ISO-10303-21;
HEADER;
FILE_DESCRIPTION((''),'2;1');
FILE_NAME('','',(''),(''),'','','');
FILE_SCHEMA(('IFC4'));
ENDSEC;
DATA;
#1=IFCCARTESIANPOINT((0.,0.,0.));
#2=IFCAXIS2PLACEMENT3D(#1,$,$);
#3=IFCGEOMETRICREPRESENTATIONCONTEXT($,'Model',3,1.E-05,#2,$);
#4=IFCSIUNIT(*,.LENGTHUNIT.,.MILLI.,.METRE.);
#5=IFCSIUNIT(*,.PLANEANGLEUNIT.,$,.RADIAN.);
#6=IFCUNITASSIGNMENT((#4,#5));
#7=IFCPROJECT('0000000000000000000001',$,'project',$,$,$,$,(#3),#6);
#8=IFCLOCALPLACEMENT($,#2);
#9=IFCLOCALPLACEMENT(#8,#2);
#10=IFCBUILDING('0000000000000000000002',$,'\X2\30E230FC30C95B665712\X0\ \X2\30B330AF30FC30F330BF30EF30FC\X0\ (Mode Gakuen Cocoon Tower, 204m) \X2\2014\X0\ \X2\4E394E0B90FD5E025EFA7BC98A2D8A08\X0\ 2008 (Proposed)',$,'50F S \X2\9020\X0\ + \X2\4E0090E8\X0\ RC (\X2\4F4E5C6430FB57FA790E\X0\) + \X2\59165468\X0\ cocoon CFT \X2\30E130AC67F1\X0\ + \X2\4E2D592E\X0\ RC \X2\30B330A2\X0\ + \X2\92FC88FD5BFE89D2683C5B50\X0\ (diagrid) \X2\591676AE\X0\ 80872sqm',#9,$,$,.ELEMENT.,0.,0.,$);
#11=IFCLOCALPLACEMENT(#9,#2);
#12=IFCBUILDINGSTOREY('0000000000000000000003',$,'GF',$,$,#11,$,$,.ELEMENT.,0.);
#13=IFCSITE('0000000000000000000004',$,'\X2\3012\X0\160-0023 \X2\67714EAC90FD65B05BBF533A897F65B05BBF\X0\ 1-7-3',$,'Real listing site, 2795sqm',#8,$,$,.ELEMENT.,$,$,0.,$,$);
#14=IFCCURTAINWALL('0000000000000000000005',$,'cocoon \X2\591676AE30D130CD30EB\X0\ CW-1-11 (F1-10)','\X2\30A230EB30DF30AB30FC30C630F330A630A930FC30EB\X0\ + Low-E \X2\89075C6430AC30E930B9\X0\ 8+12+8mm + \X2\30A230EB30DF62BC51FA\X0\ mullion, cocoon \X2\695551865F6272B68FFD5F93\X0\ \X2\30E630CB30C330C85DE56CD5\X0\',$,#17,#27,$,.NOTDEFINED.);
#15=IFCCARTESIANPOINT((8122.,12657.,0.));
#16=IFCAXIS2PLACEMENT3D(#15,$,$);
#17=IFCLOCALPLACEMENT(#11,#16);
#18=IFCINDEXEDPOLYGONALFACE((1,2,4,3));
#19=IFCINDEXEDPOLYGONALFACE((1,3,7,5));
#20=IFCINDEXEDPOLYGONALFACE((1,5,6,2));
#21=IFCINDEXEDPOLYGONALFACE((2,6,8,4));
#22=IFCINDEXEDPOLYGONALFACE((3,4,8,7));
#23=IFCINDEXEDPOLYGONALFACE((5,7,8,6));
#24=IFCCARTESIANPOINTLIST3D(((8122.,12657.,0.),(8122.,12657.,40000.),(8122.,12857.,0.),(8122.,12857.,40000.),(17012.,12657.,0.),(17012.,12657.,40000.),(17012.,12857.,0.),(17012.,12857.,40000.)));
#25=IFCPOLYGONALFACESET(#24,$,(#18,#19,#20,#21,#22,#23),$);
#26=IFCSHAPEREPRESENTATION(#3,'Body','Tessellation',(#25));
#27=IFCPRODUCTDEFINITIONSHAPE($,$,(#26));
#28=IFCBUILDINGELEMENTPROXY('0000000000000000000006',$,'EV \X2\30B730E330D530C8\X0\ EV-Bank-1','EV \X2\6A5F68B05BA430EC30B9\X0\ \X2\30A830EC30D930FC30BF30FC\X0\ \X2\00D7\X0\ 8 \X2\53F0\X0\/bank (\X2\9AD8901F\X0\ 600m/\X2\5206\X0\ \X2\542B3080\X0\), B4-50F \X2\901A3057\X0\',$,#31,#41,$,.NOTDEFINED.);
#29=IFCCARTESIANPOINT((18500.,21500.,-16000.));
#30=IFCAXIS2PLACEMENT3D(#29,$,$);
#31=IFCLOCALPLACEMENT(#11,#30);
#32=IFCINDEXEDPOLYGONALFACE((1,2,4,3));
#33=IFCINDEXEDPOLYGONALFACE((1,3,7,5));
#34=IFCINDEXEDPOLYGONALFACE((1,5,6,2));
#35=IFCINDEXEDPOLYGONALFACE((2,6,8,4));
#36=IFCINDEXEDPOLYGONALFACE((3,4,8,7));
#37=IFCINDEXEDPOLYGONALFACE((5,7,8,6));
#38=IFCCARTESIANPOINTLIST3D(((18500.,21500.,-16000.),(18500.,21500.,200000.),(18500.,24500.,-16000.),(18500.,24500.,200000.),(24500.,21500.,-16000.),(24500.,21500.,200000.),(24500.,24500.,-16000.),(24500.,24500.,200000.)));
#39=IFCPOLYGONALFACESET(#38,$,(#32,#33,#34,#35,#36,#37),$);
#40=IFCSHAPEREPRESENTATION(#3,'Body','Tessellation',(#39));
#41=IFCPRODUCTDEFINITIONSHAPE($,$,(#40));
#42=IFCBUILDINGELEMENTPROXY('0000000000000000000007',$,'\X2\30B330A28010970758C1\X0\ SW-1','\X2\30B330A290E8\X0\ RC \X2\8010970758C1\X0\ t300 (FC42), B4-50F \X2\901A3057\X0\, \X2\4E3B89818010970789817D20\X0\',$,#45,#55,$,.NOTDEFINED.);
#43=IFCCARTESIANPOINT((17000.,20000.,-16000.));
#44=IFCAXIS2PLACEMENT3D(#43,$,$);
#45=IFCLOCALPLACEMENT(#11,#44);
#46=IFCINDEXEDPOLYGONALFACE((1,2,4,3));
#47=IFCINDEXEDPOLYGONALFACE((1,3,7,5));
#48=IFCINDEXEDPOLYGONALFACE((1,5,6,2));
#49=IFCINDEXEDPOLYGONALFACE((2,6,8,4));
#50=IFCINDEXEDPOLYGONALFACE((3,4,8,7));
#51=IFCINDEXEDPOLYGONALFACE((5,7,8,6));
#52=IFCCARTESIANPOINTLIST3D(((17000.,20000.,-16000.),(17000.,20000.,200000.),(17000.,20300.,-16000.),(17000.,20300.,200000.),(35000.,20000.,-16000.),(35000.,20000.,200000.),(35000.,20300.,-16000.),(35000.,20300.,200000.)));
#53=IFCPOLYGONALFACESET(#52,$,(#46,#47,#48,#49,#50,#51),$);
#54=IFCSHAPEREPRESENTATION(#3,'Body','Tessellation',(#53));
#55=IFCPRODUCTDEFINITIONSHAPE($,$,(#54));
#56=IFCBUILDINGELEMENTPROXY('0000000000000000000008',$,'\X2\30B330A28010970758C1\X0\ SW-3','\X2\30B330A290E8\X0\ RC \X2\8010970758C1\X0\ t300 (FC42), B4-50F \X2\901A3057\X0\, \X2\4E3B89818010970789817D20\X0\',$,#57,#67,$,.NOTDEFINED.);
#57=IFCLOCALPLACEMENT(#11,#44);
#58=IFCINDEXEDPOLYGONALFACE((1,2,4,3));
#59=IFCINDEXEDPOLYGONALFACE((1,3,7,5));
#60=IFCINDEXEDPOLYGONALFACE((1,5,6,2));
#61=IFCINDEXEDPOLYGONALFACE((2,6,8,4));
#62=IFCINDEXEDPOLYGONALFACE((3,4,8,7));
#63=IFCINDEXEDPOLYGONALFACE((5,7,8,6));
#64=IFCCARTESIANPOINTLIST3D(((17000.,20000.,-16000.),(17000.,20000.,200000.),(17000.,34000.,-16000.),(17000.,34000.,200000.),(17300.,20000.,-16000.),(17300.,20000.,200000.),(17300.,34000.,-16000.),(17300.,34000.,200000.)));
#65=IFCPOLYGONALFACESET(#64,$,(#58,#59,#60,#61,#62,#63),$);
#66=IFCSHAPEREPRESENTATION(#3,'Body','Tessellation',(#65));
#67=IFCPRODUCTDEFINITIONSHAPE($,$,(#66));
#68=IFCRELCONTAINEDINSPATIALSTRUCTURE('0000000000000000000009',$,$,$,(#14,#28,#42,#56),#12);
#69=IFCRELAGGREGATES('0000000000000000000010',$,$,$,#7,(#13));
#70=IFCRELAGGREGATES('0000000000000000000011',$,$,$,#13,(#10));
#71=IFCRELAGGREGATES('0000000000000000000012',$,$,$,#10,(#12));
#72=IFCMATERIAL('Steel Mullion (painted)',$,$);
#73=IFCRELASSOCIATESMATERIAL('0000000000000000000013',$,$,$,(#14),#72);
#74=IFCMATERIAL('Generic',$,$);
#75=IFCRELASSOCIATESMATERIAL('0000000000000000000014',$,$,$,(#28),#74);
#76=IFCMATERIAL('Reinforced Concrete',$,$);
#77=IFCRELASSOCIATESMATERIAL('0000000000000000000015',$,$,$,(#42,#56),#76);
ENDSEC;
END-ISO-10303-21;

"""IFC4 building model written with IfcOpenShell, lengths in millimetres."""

from ifc_helpers import new_model, si_unit, frame, frame_2d, origin, place, context, project, spatial, rectangle, extrude, material, element, save


model = new_model("IFC4")

# Units and contexts
model_context = context("Model", 3, precision=1e-05, world=origin())
ifc_project = project(units=[si_unit("LENGTHUNIT", "METRE", prefix="MILLI"), si_unit("PLANEANGLEUNIT", "RADIAN")], contexts=[model_context])

# Site, building, storey
site_placement = place(None, origin())
site = spatial("IfcSite", under=ifc_project, at=site_placement, Name="〒160-0023 東京都新宿区西新宿 1-7-3", ObjectType="Real listing site, 2795sqm", CompositionType="ELEMENT", RefElevation=0.0)
building_placement = place(site_placement, origin())
building = spatial("IfcBuilding", under=site, at=building_placement, Name="モード学園 コクーンタワー (Mode Gakuen Cocoon Tower, 204m) — 丹下都市建築設計 2008 (Proposed)", ObjectType="50F S 造 + 一部 RC (低層・基礎) + 外周 cocoon CFT メガ柱 + 中央 RC コア + 鋼製対角格子 (diagrid) 外皮 80872sqm", CompositionType="ELEMENT", ElevationOfRefHeight=0.0, ElevationOfTerrain=0.0)
storey_placement = place(building_placement, origin())
storey = spatial("IfcBuildingStorey", under=building, at=storey_placement, Name="GF", CompositionType="ELEMENT", Elevation=0.0)

# Shared definitions
ifc_material_1 = material(Name="Reinforced Concrete")

# Curtain wall
ifc_material_2 = material(Name="Steel Mullion (painted)")
curtain_wall_1_placement = place(storey_placement, frame((8122.0, 12657.0, 0.0)))
element("IfcCurtainWall", 1, at=curtain_wall_1_placement, inside=storey, material=ifc_material_2, Name="cocoon 外皮パネル CW-1-11 (F1-10)", Description="アルミカーテンウォール + Low-E 複層ガラス 8+12+8mm + アルミ押出 mullion, cocoon 楕円形状追従 ユニット工法", PredefinedType="NOTDEFINED", context=model_context, shape_type="SweptSolid", body=[
    extrude(rectangle(XDim=8890.0, YDim=200.0, at=frame_2d((4445.0, 100.0))), frame((8122.0, 12657.0, 0.0)), (0.0, 0.0, 1.0), 40000.0),
])

# Building element proxies
ifc_material_3 = material(Name="Generic")
proxy_1_placement = place(storey_placement, frame((18500.0, 21500.0, -16000.0)))
element("IfcBuildingElementProxy", 2, at=proxy_1_placement, inside=storey, material=ifc_material_3, Name="EV シャフト EV-Bank-1", Description="EV 機械室レス エレベーター × 8 台/bank (高速 600m/分 含む), B4-50F 通し", PredefinedType="NOTDEFINED", context=model_context, shape_type="SweptSolid", body=[
    extrude(rectangle(XDim=6000.0, YDim=3000.0, at=frame_2d((3000.0, 1500.0))), frame((18500.0, 21500.0, -16000.0)), (0.0, 0.0, 1.0), 216000.0),
])
proxy_2_placement = place(storey_placement, frame((17000.0, 20000.0, -16000.0)))
element("IfcBuildingElementProxy", 3, at=proxy_2_placement, inside=storey, material=ifc_material_1, Name="コア耐震壁 SW-1", Description="コア部 RC 耐震壁 t300 (FC42), B4-50F 通し, 主要耐震要素", PredefinedType="NOTDEFINED", context=model_context, shape_type="SweptSolid", body=[
    extrude(rectangle(XDim=18000.0, YDim=300.0, at=frame_2d((9000.0, 150.0))), frame((17000.0, 20000.0, -16000.0)), (0.0, 0.0, 1.0), 216000.0),
])
proxy_3_placement = place(storey_placement, frame((17000.0, 20000.0, -16000.0)))
element("IfcBuildingElementProxy", 4, at=proxy_3_placement, inside=storey, material=ifc_material_1, Name="コア耐震壁 SW-3", Description="コア部 RC 耐震壁 t300 (FC42), B4-50F 通し, 主要耐震要素", PredefinedType="NOTDEFINED", context=model_context, shape_type="SweptSolid", body=[
    extrude(rectangle(XDim=300.0, YDim=14000.0, at=frame_2d((150.0, 7000.0))), frame((17000.0, 20000.0, -16000.0)), (0.0, 0.0, 1.0), 216000.0),
])

save(model, "model.ifc")
